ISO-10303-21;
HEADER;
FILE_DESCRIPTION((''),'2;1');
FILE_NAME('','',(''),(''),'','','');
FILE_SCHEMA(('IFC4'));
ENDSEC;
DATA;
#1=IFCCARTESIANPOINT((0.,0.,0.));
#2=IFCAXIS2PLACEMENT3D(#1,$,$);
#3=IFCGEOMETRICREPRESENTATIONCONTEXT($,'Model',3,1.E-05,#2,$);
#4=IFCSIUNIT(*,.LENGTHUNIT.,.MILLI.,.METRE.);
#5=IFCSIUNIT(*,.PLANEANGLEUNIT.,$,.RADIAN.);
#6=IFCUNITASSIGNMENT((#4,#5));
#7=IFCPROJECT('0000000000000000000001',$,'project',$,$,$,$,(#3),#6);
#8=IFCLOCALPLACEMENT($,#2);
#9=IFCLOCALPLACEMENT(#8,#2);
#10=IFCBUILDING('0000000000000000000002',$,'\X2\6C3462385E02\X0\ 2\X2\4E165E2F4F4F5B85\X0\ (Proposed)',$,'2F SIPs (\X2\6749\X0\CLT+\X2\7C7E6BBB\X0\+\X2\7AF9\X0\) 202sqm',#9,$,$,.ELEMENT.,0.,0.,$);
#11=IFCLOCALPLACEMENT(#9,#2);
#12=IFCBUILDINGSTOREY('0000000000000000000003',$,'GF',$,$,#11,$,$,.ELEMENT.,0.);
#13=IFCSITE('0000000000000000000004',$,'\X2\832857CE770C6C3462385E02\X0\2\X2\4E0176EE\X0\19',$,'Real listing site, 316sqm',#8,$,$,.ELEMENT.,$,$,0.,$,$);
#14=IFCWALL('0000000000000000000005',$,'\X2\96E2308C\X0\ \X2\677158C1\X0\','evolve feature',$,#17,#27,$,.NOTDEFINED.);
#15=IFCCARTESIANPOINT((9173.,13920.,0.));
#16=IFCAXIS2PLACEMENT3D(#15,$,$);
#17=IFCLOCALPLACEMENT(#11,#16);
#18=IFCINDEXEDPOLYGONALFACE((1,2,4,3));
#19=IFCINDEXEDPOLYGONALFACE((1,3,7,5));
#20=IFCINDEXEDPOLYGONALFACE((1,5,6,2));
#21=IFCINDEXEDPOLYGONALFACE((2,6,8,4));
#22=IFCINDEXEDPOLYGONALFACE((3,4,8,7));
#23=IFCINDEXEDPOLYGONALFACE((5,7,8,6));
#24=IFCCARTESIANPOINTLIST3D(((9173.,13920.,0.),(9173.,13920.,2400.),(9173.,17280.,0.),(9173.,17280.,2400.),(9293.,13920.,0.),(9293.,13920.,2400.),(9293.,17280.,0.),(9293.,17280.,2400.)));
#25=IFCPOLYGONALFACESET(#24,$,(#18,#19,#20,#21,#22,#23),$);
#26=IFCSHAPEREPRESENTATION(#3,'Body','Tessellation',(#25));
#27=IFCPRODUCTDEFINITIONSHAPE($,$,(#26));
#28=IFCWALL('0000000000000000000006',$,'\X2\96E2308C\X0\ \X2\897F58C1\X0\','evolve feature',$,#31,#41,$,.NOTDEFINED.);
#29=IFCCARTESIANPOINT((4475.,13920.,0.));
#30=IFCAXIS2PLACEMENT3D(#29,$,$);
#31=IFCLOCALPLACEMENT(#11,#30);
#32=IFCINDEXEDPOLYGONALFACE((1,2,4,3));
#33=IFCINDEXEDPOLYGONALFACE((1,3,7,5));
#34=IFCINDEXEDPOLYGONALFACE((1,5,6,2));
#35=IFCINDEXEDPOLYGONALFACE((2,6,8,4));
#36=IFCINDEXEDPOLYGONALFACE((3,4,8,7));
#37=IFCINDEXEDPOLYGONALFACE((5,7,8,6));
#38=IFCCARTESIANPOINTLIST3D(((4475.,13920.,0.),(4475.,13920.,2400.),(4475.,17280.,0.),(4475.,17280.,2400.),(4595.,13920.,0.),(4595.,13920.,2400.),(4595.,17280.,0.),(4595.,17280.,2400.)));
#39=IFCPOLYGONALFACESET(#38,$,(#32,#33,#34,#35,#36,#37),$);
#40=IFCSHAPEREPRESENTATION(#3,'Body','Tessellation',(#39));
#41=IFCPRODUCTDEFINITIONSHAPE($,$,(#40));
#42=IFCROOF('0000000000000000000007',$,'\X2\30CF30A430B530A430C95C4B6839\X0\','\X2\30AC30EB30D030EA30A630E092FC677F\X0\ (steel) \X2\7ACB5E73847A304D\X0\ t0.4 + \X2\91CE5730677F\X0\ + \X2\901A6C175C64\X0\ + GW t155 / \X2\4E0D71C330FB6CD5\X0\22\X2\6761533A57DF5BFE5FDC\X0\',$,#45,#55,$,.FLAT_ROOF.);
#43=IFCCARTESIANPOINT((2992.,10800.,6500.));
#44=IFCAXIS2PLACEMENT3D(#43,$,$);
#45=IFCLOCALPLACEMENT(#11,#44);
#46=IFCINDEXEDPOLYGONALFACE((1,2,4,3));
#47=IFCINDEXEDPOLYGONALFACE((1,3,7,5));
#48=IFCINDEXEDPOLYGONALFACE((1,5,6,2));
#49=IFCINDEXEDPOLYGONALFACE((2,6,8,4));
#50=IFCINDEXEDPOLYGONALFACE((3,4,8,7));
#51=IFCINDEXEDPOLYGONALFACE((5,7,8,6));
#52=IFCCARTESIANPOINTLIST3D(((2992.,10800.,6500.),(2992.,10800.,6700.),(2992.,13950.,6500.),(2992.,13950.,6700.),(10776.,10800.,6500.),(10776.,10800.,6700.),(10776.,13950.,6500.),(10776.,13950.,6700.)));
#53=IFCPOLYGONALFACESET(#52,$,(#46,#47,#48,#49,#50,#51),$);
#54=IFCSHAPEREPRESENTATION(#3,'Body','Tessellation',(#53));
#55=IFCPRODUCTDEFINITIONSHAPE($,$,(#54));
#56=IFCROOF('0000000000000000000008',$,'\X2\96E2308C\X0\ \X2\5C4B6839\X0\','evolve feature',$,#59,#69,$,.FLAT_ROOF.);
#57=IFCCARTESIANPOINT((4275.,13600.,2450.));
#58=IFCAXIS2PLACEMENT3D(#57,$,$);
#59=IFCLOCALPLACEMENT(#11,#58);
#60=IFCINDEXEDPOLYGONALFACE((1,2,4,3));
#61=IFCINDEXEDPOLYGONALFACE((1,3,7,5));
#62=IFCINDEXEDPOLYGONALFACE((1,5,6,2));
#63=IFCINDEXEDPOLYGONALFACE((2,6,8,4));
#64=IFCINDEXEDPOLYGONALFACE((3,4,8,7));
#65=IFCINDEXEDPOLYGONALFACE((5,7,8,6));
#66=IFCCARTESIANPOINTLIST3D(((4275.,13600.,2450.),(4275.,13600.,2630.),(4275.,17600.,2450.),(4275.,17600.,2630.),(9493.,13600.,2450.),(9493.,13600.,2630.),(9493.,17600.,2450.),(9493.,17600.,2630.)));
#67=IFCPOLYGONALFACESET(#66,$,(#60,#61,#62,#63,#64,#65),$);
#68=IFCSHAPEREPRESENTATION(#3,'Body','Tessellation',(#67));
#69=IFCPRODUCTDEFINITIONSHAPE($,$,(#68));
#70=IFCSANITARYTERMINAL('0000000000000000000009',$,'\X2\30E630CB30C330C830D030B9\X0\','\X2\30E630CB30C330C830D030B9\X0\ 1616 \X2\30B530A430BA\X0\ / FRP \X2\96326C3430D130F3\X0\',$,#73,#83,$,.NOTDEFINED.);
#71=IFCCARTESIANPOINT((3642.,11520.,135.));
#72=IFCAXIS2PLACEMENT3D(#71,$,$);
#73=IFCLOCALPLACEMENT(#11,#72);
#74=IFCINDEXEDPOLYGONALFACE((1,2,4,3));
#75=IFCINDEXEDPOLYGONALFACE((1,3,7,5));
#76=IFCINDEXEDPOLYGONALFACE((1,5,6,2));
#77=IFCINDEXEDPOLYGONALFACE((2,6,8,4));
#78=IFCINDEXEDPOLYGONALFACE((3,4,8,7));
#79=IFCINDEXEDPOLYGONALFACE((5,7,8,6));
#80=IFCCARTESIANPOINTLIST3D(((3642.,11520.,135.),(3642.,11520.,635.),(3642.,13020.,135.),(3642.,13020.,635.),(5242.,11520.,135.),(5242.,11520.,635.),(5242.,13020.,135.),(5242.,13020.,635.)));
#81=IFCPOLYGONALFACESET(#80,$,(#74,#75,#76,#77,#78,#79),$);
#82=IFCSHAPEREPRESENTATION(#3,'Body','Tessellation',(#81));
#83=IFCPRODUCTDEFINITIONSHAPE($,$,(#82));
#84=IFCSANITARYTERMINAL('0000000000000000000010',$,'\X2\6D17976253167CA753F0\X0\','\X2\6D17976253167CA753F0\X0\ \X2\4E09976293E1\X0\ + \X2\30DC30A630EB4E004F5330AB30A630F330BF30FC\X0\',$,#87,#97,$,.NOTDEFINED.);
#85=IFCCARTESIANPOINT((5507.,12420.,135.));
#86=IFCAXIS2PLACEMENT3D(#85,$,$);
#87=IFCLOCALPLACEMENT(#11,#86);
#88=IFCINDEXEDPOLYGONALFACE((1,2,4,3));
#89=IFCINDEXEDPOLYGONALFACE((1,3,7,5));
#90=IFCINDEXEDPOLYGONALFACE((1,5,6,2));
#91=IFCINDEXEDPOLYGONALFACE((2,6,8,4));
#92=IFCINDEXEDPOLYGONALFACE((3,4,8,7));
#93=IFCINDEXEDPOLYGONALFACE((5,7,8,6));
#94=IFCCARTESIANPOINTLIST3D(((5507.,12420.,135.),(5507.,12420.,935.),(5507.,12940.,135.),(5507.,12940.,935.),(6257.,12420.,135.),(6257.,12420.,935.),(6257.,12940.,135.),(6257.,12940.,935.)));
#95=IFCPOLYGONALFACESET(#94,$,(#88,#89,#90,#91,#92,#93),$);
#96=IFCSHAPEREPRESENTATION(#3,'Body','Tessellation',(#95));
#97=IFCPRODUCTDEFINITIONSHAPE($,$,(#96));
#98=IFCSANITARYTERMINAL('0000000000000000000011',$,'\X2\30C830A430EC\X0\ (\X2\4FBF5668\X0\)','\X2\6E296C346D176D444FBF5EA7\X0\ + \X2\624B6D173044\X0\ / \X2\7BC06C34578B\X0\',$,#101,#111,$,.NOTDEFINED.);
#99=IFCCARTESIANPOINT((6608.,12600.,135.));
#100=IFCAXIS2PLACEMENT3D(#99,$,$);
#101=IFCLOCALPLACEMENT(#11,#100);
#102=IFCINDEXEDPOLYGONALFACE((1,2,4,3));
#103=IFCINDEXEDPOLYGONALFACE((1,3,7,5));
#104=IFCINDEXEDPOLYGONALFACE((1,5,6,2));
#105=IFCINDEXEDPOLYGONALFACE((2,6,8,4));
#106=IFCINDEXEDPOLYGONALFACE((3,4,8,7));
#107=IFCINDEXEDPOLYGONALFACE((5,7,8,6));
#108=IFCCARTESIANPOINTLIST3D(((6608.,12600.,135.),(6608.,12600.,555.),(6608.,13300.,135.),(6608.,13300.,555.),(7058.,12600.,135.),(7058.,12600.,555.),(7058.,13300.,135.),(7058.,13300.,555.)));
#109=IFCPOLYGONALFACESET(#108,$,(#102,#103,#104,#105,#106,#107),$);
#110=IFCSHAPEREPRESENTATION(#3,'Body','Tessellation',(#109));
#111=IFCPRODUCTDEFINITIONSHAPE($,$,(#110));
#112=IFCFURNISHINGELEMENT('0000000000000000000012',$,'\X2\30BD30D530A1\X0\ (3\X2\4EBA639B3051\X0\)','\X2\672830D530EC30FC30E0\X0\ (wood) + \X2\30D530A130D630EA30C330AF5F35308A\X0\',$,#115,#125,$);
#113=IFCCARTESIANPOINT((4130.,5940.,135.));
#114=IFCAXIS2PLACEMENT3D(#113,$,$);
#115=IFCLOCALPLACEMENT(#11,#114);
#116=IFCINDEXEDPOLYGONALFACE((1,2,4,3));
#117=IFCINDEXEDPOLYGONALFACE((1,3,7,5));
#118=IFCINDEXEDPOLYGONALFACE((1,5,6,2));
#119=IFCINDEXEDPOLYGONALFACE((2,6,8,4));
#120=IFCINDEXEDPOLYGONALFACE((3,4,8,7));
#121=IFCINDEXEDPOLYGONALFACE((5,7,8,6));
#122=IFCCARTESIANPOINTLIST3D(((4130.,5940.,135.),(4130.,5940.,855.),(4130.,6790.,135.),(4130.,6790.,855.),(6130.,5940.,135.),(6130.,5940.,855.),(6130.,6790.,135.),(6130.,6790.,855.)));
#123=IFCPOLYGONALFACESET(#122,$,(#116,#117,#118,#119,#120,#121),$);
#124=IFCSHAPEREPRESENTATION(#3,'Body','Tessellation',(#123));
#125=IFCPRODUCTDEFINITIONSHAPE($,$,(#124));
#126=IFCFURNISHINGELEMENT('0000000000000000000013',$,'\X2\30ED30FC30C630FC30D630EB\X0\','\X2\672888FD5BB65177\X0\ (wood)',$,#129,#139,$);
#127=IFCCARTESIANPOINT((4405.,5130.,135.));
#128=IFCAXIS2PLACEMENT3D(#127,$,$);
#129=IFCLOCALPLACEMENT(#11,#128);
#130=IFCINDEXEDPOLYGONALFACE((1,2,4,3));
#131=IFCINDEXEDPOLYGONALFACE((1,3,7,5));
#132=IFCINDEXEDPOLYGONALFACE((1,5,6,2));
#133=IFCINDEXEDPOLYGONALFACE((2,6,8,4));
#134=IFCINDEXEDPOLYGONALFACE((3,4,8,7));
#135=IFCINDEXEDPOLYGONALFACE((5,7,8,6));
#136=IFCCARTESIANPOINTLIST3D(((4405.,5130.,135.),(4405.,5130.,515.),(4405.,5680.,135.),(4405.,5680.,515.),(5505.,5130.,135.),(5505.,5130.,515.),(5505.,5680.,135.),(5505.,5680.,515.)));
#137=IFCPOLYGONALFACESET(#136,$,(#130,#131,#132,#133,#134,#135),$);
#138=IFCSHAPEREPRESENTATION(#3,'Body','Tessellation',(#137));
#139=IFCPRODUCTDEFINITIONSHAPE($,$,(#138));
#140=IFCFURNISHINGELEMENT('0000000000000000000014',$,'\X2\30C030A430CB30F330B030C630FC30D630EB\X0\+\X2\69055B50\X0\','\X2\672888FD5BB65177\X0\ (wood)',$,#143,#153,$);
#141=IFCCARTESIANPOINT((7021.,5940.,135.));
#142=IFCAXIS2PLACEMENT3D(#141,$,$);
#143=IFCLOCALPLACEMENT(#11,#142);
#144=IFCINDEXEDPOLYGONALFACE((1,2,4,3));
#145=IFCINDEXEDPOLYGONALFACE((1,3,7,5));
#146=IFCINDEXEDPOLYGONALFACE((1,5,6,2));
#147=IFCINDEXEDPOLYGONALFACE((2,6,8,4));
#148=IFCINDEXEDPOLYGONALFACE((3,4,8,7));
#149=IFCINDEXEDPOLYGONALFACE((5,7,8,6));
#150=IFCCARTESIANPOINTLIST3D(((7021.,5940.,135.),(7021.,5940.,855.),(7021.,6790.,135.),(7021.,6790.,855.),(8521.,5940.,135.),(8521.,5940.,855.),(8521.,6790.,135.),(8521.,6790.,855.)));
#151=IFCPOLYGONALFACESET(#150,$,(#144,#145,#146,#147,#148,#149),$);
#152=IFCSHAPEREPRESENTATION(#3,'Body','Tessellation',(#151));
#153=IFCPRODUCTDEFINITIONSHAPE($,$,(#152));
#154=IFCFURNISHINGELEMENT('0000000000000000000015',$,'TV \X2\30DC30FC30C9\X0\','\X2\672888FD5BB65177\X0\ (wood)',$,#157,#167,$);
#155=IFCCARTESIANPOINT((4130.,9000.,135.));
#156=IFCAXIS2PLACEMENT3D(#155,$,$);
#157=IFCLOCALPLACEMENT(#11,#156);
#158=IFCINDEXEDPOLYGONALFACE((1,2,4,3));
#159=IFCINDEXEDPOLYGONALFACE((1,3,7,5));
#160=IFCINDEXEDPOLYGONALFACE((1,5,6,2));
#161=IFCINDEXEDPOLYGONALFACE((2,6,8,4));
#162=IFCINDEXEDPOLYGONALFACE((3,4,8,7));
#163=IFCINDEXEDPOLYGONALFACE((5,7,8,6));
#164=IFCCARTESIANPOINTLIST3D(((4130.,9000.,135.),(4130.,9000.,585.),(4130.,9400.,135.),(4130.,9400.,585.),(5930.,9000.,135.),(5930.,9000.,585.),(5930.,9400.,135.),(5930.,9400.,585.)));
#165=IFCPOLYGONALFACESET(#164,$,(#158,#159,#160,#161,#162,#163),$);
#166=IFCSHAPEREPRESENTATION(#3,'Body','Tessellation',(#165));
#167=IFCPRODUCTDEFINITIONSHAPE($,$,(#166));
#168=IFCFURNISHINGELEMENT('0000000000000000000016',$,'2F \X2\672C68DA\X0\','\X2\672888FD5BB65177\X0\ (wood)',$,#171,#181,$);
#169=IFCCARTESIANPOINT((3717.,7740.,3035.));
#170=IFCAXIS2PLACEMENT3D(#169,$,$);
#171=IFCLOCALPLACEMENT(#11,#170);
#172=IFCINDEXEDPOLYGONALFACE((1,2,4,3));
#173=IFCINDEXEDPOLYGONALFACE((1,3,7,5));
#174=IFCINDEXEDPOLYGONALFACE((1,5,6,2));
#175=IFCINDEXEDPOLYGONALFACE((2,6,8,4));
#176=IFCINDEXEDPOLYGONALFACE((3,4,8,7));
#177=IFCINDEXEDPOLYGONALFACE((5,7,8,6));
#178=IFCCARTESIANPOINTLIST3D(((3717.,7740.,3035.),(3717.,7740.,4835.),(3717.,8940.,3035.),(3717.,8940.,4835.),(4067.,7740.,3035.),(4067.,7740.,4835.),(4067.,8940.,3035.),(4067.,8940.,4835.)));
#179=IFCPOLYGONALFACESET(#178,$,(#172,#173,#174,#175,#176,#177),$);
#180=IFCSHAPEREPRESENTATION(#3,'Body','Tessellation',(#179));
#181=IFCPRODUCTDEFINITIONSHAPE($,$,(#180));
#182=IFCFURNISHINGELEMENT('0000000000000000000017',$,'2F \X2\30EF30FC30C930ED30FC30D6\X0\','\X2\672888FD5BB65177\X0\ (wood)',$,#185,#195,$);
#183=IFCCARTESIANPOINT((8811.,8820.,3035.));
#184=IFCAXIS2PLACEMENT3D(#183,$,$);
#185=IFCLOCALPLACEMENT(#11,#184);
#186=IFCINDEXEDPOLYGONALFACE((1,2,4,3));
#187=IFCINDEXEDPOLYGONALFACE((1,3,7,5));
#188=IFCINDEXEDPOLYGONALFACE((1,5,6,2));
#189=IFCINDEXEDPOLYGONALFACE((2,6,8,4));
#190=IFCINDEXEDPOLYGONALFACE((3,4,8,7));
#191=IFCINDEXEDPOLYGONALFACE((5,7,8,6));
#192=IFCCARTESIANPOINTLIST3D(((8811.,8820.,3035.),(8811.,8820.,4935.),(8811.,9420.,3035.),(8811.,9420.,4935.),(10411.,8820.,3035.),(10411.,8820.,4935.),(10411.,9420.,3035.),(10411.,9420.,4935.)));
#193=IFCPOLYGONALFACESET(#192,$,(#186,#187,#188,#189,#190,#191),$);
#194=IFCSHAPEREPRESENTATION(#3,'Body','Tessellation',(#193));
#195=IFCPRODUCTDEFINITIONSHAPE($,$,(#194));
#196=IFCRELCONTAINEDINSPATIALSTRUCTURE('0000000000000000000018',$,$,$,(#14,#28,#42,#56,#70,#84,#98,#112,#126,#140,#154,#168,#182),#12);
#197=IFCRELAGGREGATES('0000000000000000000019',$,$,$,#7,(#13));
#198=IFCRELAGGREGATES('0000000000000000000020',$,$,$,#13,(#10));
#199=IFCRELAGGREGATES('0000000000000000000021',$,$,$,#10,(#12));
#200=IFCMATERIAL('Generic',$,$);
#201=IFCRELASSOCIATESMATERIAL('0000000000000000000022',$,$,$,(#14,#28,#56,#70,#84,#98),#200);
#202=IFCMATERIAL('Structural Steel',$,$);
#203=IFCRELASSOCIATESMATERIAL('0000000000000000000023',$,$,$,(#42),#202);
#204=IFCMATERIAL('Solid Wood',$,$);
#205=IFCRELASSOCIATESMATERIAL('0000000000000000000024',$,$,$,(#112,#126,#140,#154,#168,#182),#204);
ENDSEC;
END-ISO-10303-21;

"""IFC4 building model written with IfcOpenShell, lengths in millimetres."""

from ifc_helpers import new_model, si_unit, frame, frame_2d, origin, place, context, project, spatial, rectangle, extrude, material, element, save


model = new_model("IFC4")

# Units and contexts
model_context = context("Model", 3, precision=1e-05, world=origin())
ifc_project = project(units=[si_unit("LENGTHUNIT", "METRE", prefix="MILLI"), si_unit("PLANEANGLEUNIT", "RADIAN")], contexts=[model_context])

# Site, building, storey
site_placement = place(None, origin())
site = spatial("IfcSite", under=ifc_project, at=site_placement, Name="茨城県水戸市2丁目19", ObjectType="Real listing site, 316sqm", CompositionType="ELEMENT", RefElevation=0.0)
building_placement = place(site_placement, origin())
building = spatial("IfcBuilding", under=site, at=building_placement, Name="水戸市 2世帯住宅 (Proposed)", ObjectType="2F SIPs (杉CLT+籾殻+竹) 202sqm", CompositionType="ELEMENT", ElevationOfRefHeight=0.0, ElevationOfTerrain=0.0)
storey_placement = place(building_placement, origin())
storey = spatial("IfcBuildingStorey", under=building, at=storey_placement, Name="GF", CompositionType="ELEMENT", Elevation=0.0)

# Shared definitions
ifc_material_1 = material(Name="Generic")

# Shared definitions
ifc_material_2 = material(Name="Solid Wood")

# Walls
wall_1_placement = place(storey_placement, frame((9173.0, 13920.0, 0.0)))
element("IfcWall", 1, at=wall_1_placement, inside=storey, material=ifc_material_1, Name="離れ 東壁", Description="evolve feature", PredefinedType="NOTDEFINED", context=model_context, shape_type="SweptSolid", body=[
    extrude(rectangle(XDim=120.0, YDim=3360.0, at=frame_2d((60.0, 1680.0))), frame((9173.0, 13920.0, 0.0)), (0.0, 0.0, 1.0), 2400.0),
])
wall_2_placement = place(storey_placement, frame((4475.0, 13920.0, 0.0)))
element("IfcWall", 2, at=wall_2_placement, inside=storey, material=ifc_material_1, Name="離れ 西壁", Description="evolve feature", PredefinedType="NOTDEFINED", context=model_context, shape_type="SweptSolid", body=[
    extrude(rectangle(XDim=120.0, YDim=3360.0, at=frame_2d((60.0, 1680.0))), frame((4475.0, 13920.0, 0.0)), (0.0, 0.0, 1.0), 2400.0),
])

# Roofs
ifc_material_3 = material(Name="Structural Steel")
roof_1_placement = place(storey_placement, frame((2992.0, 10800.0, 6500.0)))
element("IfcRoof", 3, at=roof_1_placement, inside=storey, material=ifc_material_3, Name="ハイサイド屋根", Description="ガルバリウム鋼板 (steel) 立平葺き t0.4 + 野地板 + 通気層 + GW t155 / 不燃・法22条区域対応", PredefinedType="FLAT_ROOF", context=model_context, shape_type="SweptSolid", body=[
    extrude(rectangle(XDim=7784.0, YDim=3150.0, at=frame_2d((3892.0, 1575.0))), frame((2992.0, 10800.0, 6500.0)), (0.0, 0.0, 1.0), 200.0),
])
roof_2_placement = place(storey_placement, frame((4275.0, 13600.0, 2450.0)))
element("IfcRoof", 4, at=roof_2_placement, inside=storey, material=ifc_material_1, Name="離れ 屋根", Description="evolve feature", PredefinedType="FLAT_ROOF", context=model_context, shape_type="SweptSolid", body=[
    extrude(rectangle(XDim=5218.0, YDim=4000.0, at=frame_2d((2609.0, 2000.0))), frame((4275.0, 13600.0, 2450.0)), (0.0, 0.0, 1.0), 180.0),
])

# Sanitary terminals
sanitary_terminal_1_placement = place(storey_placement, frame((3642.0, 11520.0, 135.0)))
element("IfcSanitaryTerminal", 5, at=sanitary_terminal_1_placement, inside=storey, material=ifc_material_1, Name="ユニットバス", Description="ユニットバス 1616 サイズ / FRP 防水パン", PredefinedType="NOTDEFINED", context=model_context, shape_type="SweptSolid", body=[
    extrude(rectangle(XDim=1600.0, YDim=1500.0, at=frame_2d((800.0, 750.0))), frame((3642.0, 11520.0, 135.0)), (0.0, 0.0, 1.0), 500.0),
])
sanitary_terminal_2_placement = place(storey_placement, frame((5507.0, 12420.0, 135.0)))
element("IfcSanitaryTerminal", 6, at=sanitary_terminal_2_placement, inside=storey, material=ifc_material_1, Name="洗面化粧台", Description="洗面化粧台 三面鏡 + ボウル一体カウンター", PredefinedType="NOTDEFINED", context=model_context, shape_type="SweptSolid", body=[
    extrude(rectangle(XDim=750.0, YDim=520.0, at=frame_2d((375.0, 260.0))), frame((5507.0, 12420.0, 135.0)), (0.0, 0.0, 1.0), 800.0),
])
sanitary_terminal_3_placement = place(storey_placement, frame((6608.0, 12600.0, 135.0)))
element("IfcSanitaryTerminal", 7, at=sanitary_terminal_3_placement, inside=storey, material=ifc_material_1, Name="トイレ (便器)", Description="温水洗浄便座 + 手洗い / 節水型", PredefinedType="NOTDEFINED", context=model_context, shape_type="SweptSolid", body=[
    extrude(rectangle(XDim=450.0, YDim=700.0, at=frame_2d((225.0, 350.0))), frame((6608.0, 12600.0, 135.0)), (0.0, 0.0, 1.0), 420.0),
])

# Furnishing elements
furnishing_1_placement = place(storey_placement, frame((4130.0, 5940.0, 135.0)))
element("IfcFurnishingElement", 8, at=furnishing_1_placement, inside=storey, material=ifc_material_2, Name="ソファ (3人掛け)", Description="木フレーム (wood) + ファブリック張り", context=model_context, shape_type="SweptSolid", body=[
    extrude(rectangle(XDim=2000.0, YDim=850.0, at=frame_2d((1000.0, 425.0))), frame((4130.0, 5940.0, 135.0)), (0.0, 0.0, 1.0), 720.0),
])
furnishing_2_placement = place(storey_placement, frame((4405.0, 5130.0, 135.0)))
element("IfcFurnishingElement", 9, at=furnishing_2_placement, inside=storey, material=ifc_material_2, Name="ローテーブル", Description="木製家具 (wood)", context=model_context, shape_type="SweptSolid", body=[
    extrude(rectangle(XDim=1100.0, YDim=550.0, at=frame_2d((550.0, 275.0))), frame((4405.0, 5130.0, 135.0)), (0.0, 0.0, 1.0), 380.0),
])
furnishing_3_placement = place(storey_placement, frame((7021.0, 5940.0, 135.0)))
element("IfcFurnishingElement", 10, at=furnishing_3_placement, inside=storey, material=ifc_material_2, Name="ダイニングテーブル+椅子", Description="木製家具 (wood)", context=model_context, shape_type="SweptSolid", body=[
    extrude(rectangle(XDim=1500.0, YDim=850.0, at=frame_2d((750.0, 425.0))), frame((7021.0, 5940.0, 135.0)), (0.0, 0.0, 1.0), 720.0),
])
furnishing_4_placement = place(storey_placement, frame((4130.0, 9000.0, 135.0)))
element("IfcFurnishingElement", 11, at=furnishing_4_placement, inside=storey, material=ifc_material_2, Name="TV ボード", Description="木製家具 (wood)", context=model_context, shape_type="SweptSolid", body=[
    extrude(rectangle(XDim=1800.0, YDim=400.0, at=frame_2d((900.0, 200.0))), frame((4130.0, 9000.0, 135.0)), (0.0, 0.0, 1.0), 450.0),
])
furnishing_5_placement = place(storey_placement, frame((3717.0, 7740.0, 3035.0)))
element("IfcFurnishingElement", 12, at=furnishing_5_placement, inside=storey, material=ifc_material_2, Name="2F 本棚", Description="木製家具 (wood)", context=model_context, shape_type="SweptSolid", body=[
    extrude(rectangle(XDim=350.0, YDim=1200.0, at=frame_2d((175.0, 600.0))), frame((3717.0, 7740.0, 3035.0)), (0.0, 0.0, 1.0), 1800.0),
])
furnishing_6_placement = place(storey_placement, frame((8811.0, 8820.0, 3035.0)))
element("IfcFurnishingElement", 13, at=furnishing_6_placement, inside=storey, material=ifc_material_2, Name="2F ワードローブ", Description="木製家具 (wood)", context=model_context, shape_type="SweptSolid", body=[
    extrude(rectangle(XDim=1600.0, YDim=600.0, at=frame_2d((800.0, 300.0))), frame((8811.0, 8820.0, 3035.0)), (0.0, 0.0, 1.0), 1900.0),
])

save(model, "model.ifc")
